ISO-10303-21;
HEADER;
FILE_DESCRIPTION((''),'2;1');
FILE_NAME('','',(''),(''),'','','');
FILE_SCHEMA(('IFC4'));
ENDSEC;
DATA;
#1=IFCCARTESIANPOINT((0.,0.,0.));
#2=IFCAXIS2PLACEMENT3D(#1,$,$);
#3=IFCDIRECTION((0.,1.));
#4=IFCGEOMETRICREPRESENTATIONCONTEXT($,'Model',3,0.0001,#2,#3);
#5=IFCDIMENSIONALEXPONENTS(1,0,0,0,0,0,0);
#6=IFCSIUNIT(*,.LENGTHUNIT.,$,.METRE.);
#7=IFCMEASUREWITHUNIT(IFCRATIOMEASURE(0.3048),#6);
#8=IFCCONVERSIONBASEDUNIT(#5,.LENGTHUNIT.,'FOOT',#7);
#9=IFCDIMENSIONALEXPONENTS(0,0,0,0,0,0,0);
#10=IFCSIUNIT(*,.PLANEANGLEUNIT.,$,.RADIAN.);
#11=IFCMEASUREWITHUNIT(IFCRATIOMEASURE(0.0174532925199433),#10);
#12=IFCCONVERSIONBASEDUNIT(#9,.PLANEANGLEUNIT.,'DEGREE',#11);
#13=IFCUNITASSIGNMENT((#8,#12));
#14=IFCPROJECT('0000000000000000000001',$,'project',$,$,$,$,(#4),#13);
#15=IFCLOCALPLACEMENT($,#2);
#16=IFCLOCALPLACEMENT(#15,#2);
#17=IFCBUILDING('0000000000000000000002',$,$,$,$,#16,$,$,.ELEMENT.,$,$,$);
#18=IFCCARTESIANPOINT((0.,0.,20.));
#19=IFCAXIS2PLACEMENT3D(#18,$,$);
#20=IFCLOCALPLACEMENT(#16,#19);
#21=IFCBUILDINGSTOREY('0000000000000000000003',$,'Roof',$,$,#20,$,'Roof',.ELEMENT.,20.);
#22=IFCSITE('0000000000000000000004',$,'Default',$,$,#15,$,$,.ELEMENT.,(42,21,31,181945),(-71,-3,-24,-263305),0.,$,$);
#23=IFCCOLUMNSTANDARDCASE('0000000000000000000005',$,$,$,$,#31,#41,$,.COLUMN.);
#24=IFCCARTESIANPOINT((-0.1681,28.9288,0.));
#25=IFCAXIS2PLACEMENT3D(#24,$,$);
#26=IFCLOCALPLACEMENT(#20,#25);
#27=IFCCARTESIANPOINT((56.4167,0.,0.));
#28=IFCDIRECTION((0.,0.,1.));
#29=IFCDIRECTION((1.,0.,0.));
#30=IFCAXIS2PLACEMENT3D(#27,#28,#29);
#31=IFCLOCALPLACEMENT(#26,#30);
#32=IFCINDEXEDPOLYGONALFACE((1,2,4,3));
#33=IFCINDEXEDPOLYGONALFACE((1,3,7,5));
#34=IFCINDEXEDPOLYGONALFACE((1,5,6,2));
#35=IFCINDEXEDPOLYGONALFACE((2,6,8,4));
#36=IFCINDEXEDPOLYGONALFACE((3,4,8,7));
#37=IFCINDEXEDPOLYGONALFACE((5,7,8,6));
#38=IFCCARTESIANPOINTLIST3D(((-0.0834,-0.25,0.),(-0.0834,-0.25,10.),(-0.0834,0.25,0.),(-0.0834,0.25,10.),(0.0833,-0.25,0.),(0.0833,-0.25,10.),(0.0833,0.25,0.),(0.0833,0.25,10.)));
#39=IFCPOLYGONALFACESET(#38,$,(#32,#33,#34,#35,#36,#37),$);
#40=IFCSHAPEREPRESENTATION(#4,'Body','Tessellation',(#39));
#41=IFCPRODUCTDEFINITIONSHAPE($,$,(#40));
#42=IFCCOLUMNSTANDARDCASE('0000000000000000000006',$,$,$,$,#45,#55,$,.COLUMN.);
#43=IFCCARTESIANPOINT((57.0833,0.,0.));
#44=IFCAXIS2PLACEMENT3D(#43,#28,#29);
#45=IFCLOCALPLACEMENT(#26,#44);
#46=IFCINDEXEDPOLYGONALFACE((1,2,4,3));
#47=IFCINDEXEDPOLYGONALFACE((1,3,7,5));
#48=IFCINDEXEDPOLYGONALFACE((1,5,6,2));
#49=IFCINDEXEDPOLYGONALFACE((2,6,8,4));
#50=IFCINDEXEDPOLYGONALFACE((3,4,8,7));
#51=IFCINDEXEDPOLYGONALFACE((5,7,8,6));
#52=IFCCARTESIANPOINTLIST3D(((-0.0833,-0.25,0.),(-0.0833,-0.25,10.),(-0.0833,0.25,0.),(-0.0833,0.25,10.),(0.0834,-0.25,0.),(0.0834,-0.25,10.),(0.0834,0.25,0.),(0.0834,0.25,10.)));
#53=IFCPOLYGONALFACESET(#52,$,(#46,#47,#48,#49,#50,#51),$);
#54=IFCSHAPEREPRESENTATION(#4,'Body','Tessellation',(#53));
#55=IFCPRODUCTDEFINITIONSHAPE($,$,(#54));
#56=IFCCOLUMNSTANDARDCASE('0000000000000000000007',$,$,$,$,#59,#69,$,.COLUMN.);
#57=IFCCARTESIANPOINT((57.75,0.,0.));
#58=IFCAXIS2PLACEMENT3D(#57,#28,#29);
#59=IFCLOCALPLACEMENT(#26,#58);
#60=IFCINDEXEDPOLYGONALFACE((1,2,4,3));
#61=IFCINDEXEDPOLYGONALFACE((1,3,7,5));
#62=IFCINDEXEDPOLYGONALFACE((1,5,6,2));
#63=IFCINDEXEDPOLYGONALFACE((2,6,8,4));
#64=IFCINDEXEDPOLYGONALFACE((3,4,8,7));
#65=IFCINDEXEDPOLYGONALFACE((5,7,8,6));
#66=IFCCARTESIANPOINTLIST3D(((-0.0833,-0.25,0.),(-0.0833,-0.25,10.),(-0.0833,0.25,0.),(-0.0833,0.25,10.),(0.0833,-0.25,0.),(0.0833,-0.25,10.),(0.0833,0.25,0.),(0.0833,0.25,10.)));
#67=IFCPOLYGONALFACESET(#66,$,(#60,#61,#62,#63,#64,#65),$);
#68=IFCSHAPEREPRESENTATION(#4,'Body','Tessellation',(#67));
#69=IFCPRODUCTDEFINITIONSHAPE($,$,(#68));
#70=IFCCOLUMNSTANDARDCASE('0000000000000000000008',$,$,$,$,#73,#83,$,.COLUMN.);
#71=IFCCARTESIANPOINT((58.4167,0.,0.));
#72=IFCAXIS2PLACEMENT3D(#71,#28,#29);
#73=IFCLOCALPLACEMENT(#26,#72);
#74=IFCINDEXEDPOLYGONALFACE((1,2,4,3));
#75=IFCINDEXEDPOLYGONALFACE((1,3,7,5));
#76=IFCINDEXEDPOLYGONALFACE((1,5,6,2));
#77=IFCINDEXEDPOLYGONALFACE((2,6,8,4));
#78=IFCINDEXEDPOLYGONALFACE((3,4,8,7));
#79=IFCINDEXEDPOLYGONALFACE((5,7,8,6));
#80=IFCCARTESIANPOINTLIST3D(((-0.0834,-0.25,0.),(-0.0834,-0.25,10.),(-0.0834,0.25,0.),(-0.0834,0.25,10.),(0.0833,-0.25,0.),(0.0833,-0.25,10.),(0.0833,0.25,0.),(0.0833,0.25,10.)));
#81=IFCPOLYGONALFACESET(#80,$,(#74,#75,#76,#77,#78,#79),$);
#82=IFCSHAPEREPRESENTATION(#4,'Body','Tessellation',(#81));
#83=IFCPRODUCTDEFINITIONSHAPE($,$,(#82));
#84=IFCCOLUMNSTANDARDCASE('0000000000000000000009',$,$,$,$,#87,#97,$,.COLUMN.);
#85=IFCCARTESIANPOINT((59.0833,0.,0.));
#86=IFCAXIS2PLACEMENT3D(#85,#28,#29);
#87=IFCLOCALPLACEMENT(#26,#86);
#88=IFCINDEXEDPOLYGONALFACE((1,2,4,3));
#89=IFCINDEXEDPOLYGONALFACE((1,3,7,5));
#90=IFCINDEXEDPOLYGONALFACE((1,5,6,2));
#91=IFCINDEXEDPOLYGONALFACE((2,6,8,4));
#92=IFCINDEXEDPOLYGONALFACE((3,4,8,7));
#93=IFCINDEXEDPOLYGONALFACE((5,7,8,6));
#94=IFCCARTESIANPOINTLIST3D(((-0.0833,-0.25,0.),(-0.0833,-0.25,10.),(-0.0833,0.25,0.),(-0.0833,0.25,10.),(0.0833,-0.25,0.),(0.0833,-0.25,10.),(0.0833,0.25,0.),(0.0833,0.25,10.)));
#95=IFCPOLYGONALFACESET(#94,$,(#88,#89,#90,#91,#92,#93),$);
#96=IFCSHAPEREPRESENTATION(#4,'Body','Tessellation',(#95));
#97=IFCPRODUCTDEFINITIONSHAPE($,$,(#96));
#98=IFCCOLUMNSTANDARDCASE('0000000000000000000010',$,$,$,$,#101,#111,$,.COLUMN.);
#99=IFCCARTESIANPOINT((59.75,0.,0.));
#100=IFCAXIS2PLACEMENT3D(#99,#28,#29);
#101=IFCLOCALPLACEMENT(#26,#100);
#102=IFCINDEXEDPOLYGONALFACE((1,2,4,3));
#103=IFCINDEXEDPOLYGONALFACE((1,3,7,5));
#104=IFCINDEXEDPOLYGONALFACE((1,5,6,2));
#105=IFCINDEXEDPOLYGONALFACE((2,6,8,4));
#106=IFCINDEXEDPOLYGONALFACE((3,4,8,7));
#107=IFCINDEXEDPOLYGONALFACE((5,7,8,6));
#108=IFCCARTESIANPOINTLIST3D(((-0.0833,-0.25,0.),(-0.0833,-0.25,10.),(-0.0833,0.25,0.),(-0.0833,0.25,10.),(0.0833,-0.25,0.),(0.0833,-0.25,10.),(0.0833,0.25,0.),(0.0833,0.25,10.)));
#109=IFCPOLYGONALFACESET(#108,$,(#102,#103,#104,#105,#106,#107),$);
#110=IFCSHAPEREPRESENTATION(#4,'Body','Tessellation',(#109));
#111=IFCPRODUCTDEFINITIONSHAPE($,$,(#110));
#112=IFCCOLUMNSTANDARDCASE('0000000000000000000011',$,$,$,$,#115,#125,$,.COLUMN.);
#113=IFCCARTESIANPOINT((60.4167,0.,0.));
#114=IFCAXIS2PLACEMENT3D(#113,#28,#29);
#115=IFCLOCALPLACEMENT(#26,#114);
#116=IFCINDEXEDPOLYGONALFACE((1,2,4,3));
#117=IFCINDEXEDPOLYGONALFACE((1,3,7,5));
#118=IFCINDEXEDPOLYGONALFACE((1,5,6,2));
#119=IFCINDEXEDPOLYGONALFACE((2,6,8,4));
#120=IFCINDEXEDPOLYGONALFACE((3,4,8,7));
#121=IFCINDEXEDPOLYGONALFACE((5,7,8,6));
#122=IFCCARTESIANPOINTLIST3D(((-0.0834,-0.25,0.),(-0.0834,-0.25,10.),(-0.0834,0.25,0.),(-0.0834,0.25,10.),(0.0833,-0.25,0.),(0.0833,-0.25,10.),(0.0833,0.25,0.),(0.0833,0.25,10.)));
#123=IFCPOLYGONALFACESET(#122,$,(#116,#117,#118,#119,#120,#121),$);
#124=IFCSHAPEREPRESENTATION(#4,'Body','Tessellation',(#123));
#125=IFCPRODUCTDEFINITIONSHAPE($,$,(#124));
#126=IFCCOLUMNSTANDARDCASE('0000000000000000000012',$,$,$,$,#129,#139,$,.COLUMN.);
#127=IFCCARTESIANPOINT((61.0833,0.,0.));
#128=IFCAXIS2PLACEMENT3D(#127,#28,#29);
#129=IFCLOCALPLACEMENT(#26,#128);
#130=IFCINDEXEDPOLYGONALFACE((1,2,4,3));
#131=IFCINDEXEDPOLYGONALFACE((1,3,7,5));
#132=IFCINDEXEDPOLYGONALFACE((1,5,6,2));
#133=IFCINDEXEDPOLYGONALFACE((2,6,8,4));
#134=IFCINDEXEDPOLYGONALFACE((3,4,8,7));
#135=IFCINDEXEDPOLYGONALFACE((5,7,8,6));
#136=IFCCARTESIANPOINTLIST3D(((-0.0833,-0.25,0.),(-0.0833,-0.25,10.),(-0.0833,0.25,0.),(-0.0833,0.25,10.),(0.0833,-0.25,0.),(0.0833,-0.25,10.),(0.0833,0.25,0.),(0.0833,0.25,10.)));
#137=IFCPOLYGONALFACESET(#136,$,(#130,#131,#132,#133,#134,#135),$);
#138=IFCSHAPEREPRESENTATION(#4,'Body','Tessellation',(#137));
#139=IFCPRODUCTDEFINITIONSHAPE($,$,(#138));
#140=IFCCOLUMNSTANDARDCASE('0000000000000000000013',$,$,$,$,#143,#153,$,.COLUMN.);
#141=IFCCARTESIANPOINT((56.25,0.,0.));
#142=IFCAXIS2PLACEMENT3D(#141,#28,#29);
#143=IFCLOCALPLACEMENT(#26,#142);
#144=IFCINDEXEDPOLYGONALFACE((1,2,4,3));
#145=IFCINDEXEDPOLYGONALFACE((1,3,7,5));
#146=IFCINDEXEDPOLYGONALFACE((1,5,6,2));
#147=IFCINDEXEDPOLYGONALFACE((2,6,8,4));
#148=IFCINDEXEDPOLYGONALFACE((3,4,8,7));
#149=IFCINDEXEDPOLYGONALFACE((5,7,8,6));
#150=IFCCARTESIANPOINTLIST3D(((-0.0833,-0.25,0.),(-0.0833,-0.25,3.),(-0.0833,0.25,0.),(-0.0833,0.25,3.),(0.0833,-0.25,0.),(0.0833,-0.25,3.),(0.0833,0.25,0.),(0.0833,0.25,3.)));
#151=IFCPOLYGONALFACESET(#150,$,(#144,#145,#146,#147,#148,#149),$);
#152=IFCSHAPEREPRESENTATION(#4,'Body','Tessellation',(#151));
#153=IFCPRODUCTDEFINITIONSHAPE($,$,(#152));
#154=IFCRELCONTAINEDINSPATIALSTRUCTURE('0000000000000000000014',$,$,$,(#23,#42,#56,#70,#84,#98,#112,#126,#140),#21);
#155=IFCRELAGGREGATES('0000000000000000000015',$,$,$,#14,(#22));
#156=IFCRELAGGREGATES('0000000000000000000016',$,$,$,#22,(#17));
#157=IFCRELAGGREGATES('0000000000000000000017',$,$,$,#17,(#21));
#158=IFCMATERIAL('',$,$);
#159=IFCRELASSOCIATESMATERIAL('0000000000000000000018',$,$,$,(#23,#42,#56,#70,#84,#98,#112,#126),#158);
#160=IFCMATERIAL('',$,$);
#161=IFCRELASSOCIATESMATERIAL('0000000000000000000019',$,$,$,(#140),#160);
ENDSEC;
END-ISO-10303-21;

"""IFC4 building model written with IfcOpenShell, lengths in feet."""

from ifc_helpers import new_model, entity, si_unit, converted_unit, direction, frame, origin, place, context, project, spatial, rectangle, extrude, material, element, save


model = new_model("IFC4")

# Units and contexts
model_context = context("Model", 3, precision=0.0001, world=origin(), true_north=direction((0.0, 1.0)))
ifc_project = project(units=[converted_unit("LENGTHUNIT", "FOOT", entity("IfcRatioMeasure", 0.3048), si_unit("LENGTHUNIT", "METRE"), dimensions=[1, 0, 0, 0, 0, 0, 0]), converted_unit("PLANEANGLEUNIT", "DEGREE", entity("IfcRatioMeasure", 0.0174532925199433), si_unit("PLANEANGLEUNIT", "RADIAN"), dimensions=[0, 0, 0, 0, 0, 0, 0])], contexts=[model_context])

# Site, building, storey
site_placement = place(None, origin())
site = spatial("IfcSite", under=ifc_project, at=site_placement, Name="Default", CompositionType="ELEMENT", RefLatitude=(42, 21, 31, 181945), RefLongitude=(-71, -3, -24, -263305), RefElevation=0.0)
building_placement = place(site_placement, origin())
building = spatial("IfcBuilding", under=site, at=building_placement, CompositionType="ELEMENT")
storey_placement = place(building_placement, frame((0.0, 0.0, 20.0)))
storey = spatial("IfcBuildingStorey", under=building, at=storey_placement, Name="Roof", LongName="Roof", CompositionType="ELEMENT", Elevation=20.0)

# Columns
ifc_material_1 = material(Name="")
placement = place(storey_placement, frame((-0.1681, 28.9288, 0.0)))
for number, where, z_axis, x_axis in (
    (1, (56.4167, 0.0, 0.0), (0.0, 0.0, 1.0), (1.0, 0.0, 0.0)),
    (2, (57.0833, 0.0, 0.0), (0.0, 0.0, 1.0), (1.0, 0.0, 0.0)),
    (3, (57.75, 0.0, 0.0), (0.0, 0.0, 1.0), (1.0, 0.0, 0.0)),
    (4, (58.4167, 0.0, 0.0), (0.0, 0.0, 1.0), (1.0, 0.0, 0.0)),
    (5, (59.0833, 0.0, 0.0), (0.0, 0.0, 1.0), (1.0, 0.0, 0.0)),
    (6, (59.75, 0.0, 0.0), (0.0, 0.0, 1.0), (1.0, 0.0, 0.0)),
    (7, (60.4167, 0.0, 0.0), (0.0, 0.0, 1.0), (1.0, 0.0, 0.0)),
    (8, (61.0833, 0.0, 0.0), (0.0, 0.0, 1.0), (1.0, 0.0, 0.0)),
):
    element("IfcColumnStandardCase", number, at=place(placement, frame(where, z_axis=z_axis, x_axis=x_axis)), inside=storey, material=ifc_material_1, PredefinedType="COLUMN", context=model_context, shape_type="SweptSolid", body=[
        extrude(rectangle(XDim=0.1667, YDim=0.5), origin(), (0.0, 0.0, 1.0), 10.0),
    ])
ifc_material_2 = material(Name="")
for number, where, z_axis, x_axis in (
    (9, (56.25, 0.0, 0.0), (0.0, 0.0, 1.0), (1.0, 0.0, 0.0)),
):
    element("IfcColumnStandardCase", number, at=place(placement, frame(where, z_axis=z_axis, x_axis=x_axis)), inside=storey, material=ifc_material_2, PredefinedType="COLUMN", context=model_context, shape_type="SweptSolid", body=[
        extrude(rectangle(XDim=0.1667, YDim=0.5), origin(), (0.0, 0.0, 1.0), 3.0),
    ])

save(model, "model.ifc")
